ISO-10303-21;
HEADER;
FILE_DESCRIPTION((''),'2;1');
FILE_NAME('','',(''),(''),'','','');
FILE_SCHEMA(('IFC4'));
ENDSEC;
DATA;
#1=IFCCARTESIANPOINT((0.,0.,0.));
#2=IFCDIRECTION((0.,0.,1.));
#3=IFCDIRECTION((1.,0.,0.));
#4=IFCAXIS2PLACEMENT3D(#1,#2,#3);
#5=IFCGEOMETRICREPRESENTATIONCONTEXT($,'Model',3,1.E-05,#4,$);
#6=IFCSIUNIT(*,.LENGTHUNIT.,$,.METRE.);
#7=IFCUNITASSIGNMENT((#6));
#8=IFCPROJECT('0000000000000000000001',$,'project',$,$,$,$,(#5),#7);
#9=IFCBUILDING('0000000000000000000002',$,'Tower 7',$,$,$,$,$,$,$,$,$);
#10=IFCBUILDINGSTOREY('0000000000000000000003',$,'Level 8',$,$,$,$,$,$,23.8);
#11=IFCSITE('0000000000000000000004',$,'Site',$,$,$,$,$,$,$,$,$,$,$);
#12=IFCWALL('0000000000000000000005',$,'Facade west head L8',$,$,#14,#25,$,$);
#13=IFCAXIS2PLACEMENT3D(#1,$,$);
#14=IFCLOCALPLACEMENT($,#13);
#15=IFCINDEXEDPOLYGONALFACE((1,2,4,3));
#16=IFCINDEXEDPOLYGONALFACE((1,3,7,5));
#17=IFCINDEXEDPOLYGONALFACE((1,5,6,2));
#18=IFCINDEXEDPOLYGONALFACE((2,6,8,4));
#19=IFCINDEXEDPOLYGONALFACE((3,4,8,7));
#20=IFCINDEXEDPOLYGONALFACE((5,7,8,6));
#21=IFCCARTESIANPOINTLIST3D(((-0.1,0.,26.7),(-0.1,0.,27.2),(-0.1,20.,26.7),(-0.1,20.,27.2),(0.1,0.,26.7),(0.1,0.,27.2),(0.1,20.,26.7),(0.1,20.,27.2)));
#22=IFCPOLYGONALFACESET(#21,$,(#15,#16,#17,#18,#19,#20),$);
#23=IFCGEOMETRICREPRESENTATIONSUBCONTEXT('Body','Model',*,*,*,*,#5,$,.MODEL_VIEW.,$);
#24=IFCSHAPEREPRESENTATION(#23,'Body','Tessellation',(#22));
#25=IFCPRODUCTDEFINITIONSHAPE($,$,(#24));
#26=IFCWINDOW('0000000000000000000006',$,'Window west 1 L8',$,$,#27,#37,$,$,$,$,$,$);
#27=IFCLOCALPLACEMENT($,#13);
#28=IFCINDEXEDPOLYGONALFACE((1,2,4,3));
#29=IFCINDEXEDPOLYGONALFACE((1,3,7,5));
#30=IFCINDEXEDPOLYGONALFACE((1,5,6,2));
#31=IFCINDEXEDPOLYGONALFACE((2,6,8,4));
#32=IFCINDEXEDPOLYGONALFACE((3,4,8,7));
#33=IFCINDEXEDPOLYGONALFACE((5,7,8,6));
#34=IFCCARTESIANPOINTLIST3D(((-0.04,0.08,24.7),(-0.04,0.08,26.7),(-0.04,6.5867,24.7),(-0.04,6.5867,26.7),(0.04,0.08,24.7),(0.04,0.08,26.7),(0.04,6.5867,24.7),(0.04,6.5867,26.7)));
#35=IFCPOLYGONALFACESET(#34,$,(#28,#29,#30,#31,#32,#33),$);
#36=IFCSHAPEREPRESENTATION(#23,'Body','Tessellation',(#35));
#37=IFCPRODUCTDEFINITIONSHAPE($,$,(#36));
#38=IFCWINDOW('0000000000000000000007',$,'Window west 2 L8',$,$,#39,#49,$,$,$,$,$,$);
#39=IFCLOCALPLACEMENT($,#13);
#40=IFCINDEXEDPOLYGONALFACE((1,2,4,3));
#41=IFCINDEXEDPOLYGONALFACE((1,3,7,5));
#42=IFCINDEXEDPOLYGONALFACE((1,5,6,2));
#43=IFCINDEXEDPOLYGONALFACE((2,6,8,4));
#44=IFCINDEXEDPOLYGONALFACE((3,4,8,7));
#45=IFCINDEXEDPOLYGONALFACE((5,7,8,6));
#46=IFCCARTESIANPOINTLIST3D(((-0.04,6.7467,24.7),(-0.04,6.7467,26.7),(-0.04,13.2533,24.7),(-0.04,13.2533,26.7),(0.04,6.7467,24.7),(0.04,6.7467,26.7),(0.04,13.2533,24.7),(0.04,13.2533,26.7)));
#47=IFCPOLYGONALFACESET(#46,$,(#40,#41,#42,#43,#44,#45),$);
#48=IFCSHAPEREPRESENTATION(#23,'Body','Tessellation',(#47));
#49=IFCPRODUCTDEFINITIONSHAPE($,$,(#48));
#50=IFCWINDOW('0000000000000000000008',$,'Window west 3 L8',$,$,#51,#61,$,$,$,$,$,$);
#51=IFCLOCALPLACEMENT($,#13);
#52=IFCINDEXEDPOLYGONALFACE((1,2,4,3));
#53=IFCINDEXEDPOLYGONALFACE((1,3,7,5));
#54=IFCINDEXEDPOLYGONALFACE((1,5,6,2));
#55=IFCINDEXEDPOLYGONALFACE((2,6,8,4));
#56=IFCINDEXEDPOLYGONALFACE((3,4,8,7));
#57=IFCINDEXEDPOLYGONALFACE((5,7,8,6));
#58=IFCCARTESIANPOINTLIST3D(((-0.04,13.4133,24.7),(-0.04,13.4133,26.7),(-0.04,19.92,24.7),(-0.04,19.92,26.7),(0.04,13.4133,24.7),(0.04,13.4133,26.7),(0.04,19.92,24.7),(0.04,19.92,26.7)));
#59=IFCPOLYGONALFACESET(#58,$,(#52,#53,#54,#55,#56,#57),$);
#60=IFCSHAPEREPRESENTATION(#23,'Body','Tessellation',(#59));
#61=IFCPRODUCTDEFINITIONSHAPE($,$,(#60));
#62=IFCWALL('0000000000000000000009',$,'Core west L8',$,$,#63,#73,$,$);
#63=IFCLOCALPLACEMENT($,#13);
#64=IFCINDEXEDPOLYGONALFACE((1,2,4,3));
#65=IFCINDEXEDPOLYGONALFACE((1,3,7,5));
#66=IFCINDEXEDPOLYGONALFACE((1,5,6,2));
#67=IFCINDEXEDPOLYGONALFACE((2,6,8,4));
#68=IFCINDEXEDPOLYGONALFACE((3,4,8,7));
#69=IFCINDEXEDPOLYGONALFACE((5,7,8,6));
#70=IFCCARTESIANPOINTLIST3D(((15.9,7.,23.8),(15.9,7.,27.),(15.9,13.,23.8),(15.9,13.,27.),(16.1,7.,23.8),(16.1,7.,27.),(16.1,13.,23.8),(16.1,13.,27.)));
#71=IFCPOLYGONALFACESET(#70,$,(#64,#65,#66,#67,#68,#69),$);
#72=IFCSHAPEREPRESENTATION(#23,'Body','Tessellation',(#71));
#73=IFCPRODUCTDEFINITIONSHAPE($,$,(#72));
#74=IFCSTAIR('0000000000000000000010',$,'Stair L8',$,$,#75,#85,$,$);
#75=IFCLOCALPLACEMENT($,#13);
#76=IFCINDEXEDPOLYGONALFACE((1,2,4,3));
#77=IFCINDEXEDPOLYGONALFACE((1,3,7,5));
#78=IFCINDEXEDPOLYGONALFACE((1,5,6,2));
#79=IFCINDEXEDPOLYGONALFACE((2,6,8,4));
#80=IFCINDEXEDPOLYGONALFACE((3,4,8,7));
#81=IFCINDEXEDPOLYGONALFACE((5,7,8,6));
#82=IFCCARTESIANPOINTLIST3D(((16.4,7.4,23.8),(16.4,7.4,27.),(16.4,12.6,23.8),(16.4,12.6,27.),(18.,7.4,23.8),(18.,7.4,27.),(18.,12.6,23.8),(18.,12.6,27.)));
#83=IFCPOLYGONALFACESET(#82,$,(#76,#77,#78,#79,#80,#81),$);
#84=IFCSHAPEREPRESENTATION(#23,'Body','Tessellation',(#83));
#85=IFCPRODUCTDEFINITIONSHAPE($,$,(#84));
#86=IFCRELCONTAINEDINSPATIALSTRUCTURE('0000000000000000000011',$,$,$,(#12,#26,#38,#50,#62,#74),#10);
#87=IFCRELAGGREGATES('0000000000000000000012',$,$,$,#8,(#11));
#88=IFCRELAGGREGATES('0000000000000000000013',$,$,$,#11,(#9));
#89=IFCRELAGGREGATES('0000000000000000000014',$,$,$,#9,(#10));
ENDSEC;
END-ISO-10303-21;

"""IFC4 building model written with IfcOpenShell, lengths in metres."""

from ifc_helpers import new_model, si_unit, frame, origin, origin_with_axes, origin_2d, place, context, subcontext, project, spatial, rectangle, extrude, element, save


model = new_model("IFC4")

# Units and contexts
model_context = context("Model", 3, precision=1e-05, world=origin_with_axes())
body_context = subcontext(model_context, "Body", "Model", "MODEL_VIEW")
ifc_project = project(units=[si_unit("LENGTHUNIT", "METRE")], contexts=[model_context])

# Site, building, storey
site = spatial("IfcSite", under=ifc_project, Name="Site")
building = spatial("IfcBuilding", under=site, Name="Tower 7")
storey = spatial("IfcBuildingStorey", under=building, Name="Level 8", Elevation=23.8)

# Wall
wall_1_placement = place(None, frame((0.0, 10.0, 26.7), z_axis=(0.0, 0.0, 1.0), x_axis=(1.0, 0.0, 0.0)))
element("IfcWall", 1, at=wall_1_placement, inside=storey, Name="Facade west head L8", context=body_context, shape_type="SweptSolid", body=[
    extrude(rectangle(XDim=0.2, YDim=20.0, at=origin_2d()), origin(), (0.0, 0.0, 1.0), 0.5),
])

# Windows
for number, where, z_axis, x_axis, name in (
    (2, (0.0, 3.3333, 24.7), (0.0, 0.0, 1.0), (1.0, 0.0, 0.0), "Window west 1 L8"),
    (3, (0.0, 10.0, 24.7), (0.0, 0.0, 1.0), (1.0, 0.0, 0.0), "Window west 2 L8"),
):
    element("IfcWindow", number, at=place(None, frame(where, z_axis=z_axis, x_axis=x_axis)), inside=storey, Name=name, context=body_context, shape_type="SweptSolid", body=[
        extrude(rectangle(XDim=0.08, YDim=6.5067, at=origin_2d()), origin(), (0.0, 0.0, 1.0), 2.0),
    ])
window_1_placement = place(None, frame((0.0, 16.6667, 24.7), z_axis=(0.0, 0.0, 1.0), x_axis=(1.0, 0.0, 0.0)))
element("IfcWindow", 4, at=window_1_placement, inside=storey, Name="Window west 3 L8", context=body_context, shape_type="SweptSolid", body=[
    extrude(rectangle(XDim=0.08, YDim=6.5067, at=origin_2d()), origin(), (0.0, 0.0, 1.0), 2.0),
])

# Wall
wall_2_placement = place(None, frame((16.0, 10.0, 23.8), z_axis=(0.0, 0.0, 1.0), x_axis=(1.0, 0.0, 0.0)))
element("IfcWall", 5, at=wall_2_placement, inside=storey, Name="Core west L8", context=body_context, shape_type="SweptSolid", body=[
    extrude(rectangle(XDim=0.2, YDim=6.0, at=origin_2d()), origin(), (0.0, 0.0, 1.0), 3.2),
])

# Stair
stair_placement = place(None, frame((17.2, 10.0, 23.8), z_axis=(0.0, 0.0, 1.0), x_axis=(1.0, 0.0, 0.0)))
element("IfcStair", 6, at=stair_placement, inside=storey, Name="Stair L8", context=body_context, shape_type="SweptSolid", body=[
    extrude(rectangle(XDim=1.6, YDim=5.2, at=origin_2d()), origin(), (0.0, 0.0, 1.0), 3.2),
])

save(model, "model.ifc")
